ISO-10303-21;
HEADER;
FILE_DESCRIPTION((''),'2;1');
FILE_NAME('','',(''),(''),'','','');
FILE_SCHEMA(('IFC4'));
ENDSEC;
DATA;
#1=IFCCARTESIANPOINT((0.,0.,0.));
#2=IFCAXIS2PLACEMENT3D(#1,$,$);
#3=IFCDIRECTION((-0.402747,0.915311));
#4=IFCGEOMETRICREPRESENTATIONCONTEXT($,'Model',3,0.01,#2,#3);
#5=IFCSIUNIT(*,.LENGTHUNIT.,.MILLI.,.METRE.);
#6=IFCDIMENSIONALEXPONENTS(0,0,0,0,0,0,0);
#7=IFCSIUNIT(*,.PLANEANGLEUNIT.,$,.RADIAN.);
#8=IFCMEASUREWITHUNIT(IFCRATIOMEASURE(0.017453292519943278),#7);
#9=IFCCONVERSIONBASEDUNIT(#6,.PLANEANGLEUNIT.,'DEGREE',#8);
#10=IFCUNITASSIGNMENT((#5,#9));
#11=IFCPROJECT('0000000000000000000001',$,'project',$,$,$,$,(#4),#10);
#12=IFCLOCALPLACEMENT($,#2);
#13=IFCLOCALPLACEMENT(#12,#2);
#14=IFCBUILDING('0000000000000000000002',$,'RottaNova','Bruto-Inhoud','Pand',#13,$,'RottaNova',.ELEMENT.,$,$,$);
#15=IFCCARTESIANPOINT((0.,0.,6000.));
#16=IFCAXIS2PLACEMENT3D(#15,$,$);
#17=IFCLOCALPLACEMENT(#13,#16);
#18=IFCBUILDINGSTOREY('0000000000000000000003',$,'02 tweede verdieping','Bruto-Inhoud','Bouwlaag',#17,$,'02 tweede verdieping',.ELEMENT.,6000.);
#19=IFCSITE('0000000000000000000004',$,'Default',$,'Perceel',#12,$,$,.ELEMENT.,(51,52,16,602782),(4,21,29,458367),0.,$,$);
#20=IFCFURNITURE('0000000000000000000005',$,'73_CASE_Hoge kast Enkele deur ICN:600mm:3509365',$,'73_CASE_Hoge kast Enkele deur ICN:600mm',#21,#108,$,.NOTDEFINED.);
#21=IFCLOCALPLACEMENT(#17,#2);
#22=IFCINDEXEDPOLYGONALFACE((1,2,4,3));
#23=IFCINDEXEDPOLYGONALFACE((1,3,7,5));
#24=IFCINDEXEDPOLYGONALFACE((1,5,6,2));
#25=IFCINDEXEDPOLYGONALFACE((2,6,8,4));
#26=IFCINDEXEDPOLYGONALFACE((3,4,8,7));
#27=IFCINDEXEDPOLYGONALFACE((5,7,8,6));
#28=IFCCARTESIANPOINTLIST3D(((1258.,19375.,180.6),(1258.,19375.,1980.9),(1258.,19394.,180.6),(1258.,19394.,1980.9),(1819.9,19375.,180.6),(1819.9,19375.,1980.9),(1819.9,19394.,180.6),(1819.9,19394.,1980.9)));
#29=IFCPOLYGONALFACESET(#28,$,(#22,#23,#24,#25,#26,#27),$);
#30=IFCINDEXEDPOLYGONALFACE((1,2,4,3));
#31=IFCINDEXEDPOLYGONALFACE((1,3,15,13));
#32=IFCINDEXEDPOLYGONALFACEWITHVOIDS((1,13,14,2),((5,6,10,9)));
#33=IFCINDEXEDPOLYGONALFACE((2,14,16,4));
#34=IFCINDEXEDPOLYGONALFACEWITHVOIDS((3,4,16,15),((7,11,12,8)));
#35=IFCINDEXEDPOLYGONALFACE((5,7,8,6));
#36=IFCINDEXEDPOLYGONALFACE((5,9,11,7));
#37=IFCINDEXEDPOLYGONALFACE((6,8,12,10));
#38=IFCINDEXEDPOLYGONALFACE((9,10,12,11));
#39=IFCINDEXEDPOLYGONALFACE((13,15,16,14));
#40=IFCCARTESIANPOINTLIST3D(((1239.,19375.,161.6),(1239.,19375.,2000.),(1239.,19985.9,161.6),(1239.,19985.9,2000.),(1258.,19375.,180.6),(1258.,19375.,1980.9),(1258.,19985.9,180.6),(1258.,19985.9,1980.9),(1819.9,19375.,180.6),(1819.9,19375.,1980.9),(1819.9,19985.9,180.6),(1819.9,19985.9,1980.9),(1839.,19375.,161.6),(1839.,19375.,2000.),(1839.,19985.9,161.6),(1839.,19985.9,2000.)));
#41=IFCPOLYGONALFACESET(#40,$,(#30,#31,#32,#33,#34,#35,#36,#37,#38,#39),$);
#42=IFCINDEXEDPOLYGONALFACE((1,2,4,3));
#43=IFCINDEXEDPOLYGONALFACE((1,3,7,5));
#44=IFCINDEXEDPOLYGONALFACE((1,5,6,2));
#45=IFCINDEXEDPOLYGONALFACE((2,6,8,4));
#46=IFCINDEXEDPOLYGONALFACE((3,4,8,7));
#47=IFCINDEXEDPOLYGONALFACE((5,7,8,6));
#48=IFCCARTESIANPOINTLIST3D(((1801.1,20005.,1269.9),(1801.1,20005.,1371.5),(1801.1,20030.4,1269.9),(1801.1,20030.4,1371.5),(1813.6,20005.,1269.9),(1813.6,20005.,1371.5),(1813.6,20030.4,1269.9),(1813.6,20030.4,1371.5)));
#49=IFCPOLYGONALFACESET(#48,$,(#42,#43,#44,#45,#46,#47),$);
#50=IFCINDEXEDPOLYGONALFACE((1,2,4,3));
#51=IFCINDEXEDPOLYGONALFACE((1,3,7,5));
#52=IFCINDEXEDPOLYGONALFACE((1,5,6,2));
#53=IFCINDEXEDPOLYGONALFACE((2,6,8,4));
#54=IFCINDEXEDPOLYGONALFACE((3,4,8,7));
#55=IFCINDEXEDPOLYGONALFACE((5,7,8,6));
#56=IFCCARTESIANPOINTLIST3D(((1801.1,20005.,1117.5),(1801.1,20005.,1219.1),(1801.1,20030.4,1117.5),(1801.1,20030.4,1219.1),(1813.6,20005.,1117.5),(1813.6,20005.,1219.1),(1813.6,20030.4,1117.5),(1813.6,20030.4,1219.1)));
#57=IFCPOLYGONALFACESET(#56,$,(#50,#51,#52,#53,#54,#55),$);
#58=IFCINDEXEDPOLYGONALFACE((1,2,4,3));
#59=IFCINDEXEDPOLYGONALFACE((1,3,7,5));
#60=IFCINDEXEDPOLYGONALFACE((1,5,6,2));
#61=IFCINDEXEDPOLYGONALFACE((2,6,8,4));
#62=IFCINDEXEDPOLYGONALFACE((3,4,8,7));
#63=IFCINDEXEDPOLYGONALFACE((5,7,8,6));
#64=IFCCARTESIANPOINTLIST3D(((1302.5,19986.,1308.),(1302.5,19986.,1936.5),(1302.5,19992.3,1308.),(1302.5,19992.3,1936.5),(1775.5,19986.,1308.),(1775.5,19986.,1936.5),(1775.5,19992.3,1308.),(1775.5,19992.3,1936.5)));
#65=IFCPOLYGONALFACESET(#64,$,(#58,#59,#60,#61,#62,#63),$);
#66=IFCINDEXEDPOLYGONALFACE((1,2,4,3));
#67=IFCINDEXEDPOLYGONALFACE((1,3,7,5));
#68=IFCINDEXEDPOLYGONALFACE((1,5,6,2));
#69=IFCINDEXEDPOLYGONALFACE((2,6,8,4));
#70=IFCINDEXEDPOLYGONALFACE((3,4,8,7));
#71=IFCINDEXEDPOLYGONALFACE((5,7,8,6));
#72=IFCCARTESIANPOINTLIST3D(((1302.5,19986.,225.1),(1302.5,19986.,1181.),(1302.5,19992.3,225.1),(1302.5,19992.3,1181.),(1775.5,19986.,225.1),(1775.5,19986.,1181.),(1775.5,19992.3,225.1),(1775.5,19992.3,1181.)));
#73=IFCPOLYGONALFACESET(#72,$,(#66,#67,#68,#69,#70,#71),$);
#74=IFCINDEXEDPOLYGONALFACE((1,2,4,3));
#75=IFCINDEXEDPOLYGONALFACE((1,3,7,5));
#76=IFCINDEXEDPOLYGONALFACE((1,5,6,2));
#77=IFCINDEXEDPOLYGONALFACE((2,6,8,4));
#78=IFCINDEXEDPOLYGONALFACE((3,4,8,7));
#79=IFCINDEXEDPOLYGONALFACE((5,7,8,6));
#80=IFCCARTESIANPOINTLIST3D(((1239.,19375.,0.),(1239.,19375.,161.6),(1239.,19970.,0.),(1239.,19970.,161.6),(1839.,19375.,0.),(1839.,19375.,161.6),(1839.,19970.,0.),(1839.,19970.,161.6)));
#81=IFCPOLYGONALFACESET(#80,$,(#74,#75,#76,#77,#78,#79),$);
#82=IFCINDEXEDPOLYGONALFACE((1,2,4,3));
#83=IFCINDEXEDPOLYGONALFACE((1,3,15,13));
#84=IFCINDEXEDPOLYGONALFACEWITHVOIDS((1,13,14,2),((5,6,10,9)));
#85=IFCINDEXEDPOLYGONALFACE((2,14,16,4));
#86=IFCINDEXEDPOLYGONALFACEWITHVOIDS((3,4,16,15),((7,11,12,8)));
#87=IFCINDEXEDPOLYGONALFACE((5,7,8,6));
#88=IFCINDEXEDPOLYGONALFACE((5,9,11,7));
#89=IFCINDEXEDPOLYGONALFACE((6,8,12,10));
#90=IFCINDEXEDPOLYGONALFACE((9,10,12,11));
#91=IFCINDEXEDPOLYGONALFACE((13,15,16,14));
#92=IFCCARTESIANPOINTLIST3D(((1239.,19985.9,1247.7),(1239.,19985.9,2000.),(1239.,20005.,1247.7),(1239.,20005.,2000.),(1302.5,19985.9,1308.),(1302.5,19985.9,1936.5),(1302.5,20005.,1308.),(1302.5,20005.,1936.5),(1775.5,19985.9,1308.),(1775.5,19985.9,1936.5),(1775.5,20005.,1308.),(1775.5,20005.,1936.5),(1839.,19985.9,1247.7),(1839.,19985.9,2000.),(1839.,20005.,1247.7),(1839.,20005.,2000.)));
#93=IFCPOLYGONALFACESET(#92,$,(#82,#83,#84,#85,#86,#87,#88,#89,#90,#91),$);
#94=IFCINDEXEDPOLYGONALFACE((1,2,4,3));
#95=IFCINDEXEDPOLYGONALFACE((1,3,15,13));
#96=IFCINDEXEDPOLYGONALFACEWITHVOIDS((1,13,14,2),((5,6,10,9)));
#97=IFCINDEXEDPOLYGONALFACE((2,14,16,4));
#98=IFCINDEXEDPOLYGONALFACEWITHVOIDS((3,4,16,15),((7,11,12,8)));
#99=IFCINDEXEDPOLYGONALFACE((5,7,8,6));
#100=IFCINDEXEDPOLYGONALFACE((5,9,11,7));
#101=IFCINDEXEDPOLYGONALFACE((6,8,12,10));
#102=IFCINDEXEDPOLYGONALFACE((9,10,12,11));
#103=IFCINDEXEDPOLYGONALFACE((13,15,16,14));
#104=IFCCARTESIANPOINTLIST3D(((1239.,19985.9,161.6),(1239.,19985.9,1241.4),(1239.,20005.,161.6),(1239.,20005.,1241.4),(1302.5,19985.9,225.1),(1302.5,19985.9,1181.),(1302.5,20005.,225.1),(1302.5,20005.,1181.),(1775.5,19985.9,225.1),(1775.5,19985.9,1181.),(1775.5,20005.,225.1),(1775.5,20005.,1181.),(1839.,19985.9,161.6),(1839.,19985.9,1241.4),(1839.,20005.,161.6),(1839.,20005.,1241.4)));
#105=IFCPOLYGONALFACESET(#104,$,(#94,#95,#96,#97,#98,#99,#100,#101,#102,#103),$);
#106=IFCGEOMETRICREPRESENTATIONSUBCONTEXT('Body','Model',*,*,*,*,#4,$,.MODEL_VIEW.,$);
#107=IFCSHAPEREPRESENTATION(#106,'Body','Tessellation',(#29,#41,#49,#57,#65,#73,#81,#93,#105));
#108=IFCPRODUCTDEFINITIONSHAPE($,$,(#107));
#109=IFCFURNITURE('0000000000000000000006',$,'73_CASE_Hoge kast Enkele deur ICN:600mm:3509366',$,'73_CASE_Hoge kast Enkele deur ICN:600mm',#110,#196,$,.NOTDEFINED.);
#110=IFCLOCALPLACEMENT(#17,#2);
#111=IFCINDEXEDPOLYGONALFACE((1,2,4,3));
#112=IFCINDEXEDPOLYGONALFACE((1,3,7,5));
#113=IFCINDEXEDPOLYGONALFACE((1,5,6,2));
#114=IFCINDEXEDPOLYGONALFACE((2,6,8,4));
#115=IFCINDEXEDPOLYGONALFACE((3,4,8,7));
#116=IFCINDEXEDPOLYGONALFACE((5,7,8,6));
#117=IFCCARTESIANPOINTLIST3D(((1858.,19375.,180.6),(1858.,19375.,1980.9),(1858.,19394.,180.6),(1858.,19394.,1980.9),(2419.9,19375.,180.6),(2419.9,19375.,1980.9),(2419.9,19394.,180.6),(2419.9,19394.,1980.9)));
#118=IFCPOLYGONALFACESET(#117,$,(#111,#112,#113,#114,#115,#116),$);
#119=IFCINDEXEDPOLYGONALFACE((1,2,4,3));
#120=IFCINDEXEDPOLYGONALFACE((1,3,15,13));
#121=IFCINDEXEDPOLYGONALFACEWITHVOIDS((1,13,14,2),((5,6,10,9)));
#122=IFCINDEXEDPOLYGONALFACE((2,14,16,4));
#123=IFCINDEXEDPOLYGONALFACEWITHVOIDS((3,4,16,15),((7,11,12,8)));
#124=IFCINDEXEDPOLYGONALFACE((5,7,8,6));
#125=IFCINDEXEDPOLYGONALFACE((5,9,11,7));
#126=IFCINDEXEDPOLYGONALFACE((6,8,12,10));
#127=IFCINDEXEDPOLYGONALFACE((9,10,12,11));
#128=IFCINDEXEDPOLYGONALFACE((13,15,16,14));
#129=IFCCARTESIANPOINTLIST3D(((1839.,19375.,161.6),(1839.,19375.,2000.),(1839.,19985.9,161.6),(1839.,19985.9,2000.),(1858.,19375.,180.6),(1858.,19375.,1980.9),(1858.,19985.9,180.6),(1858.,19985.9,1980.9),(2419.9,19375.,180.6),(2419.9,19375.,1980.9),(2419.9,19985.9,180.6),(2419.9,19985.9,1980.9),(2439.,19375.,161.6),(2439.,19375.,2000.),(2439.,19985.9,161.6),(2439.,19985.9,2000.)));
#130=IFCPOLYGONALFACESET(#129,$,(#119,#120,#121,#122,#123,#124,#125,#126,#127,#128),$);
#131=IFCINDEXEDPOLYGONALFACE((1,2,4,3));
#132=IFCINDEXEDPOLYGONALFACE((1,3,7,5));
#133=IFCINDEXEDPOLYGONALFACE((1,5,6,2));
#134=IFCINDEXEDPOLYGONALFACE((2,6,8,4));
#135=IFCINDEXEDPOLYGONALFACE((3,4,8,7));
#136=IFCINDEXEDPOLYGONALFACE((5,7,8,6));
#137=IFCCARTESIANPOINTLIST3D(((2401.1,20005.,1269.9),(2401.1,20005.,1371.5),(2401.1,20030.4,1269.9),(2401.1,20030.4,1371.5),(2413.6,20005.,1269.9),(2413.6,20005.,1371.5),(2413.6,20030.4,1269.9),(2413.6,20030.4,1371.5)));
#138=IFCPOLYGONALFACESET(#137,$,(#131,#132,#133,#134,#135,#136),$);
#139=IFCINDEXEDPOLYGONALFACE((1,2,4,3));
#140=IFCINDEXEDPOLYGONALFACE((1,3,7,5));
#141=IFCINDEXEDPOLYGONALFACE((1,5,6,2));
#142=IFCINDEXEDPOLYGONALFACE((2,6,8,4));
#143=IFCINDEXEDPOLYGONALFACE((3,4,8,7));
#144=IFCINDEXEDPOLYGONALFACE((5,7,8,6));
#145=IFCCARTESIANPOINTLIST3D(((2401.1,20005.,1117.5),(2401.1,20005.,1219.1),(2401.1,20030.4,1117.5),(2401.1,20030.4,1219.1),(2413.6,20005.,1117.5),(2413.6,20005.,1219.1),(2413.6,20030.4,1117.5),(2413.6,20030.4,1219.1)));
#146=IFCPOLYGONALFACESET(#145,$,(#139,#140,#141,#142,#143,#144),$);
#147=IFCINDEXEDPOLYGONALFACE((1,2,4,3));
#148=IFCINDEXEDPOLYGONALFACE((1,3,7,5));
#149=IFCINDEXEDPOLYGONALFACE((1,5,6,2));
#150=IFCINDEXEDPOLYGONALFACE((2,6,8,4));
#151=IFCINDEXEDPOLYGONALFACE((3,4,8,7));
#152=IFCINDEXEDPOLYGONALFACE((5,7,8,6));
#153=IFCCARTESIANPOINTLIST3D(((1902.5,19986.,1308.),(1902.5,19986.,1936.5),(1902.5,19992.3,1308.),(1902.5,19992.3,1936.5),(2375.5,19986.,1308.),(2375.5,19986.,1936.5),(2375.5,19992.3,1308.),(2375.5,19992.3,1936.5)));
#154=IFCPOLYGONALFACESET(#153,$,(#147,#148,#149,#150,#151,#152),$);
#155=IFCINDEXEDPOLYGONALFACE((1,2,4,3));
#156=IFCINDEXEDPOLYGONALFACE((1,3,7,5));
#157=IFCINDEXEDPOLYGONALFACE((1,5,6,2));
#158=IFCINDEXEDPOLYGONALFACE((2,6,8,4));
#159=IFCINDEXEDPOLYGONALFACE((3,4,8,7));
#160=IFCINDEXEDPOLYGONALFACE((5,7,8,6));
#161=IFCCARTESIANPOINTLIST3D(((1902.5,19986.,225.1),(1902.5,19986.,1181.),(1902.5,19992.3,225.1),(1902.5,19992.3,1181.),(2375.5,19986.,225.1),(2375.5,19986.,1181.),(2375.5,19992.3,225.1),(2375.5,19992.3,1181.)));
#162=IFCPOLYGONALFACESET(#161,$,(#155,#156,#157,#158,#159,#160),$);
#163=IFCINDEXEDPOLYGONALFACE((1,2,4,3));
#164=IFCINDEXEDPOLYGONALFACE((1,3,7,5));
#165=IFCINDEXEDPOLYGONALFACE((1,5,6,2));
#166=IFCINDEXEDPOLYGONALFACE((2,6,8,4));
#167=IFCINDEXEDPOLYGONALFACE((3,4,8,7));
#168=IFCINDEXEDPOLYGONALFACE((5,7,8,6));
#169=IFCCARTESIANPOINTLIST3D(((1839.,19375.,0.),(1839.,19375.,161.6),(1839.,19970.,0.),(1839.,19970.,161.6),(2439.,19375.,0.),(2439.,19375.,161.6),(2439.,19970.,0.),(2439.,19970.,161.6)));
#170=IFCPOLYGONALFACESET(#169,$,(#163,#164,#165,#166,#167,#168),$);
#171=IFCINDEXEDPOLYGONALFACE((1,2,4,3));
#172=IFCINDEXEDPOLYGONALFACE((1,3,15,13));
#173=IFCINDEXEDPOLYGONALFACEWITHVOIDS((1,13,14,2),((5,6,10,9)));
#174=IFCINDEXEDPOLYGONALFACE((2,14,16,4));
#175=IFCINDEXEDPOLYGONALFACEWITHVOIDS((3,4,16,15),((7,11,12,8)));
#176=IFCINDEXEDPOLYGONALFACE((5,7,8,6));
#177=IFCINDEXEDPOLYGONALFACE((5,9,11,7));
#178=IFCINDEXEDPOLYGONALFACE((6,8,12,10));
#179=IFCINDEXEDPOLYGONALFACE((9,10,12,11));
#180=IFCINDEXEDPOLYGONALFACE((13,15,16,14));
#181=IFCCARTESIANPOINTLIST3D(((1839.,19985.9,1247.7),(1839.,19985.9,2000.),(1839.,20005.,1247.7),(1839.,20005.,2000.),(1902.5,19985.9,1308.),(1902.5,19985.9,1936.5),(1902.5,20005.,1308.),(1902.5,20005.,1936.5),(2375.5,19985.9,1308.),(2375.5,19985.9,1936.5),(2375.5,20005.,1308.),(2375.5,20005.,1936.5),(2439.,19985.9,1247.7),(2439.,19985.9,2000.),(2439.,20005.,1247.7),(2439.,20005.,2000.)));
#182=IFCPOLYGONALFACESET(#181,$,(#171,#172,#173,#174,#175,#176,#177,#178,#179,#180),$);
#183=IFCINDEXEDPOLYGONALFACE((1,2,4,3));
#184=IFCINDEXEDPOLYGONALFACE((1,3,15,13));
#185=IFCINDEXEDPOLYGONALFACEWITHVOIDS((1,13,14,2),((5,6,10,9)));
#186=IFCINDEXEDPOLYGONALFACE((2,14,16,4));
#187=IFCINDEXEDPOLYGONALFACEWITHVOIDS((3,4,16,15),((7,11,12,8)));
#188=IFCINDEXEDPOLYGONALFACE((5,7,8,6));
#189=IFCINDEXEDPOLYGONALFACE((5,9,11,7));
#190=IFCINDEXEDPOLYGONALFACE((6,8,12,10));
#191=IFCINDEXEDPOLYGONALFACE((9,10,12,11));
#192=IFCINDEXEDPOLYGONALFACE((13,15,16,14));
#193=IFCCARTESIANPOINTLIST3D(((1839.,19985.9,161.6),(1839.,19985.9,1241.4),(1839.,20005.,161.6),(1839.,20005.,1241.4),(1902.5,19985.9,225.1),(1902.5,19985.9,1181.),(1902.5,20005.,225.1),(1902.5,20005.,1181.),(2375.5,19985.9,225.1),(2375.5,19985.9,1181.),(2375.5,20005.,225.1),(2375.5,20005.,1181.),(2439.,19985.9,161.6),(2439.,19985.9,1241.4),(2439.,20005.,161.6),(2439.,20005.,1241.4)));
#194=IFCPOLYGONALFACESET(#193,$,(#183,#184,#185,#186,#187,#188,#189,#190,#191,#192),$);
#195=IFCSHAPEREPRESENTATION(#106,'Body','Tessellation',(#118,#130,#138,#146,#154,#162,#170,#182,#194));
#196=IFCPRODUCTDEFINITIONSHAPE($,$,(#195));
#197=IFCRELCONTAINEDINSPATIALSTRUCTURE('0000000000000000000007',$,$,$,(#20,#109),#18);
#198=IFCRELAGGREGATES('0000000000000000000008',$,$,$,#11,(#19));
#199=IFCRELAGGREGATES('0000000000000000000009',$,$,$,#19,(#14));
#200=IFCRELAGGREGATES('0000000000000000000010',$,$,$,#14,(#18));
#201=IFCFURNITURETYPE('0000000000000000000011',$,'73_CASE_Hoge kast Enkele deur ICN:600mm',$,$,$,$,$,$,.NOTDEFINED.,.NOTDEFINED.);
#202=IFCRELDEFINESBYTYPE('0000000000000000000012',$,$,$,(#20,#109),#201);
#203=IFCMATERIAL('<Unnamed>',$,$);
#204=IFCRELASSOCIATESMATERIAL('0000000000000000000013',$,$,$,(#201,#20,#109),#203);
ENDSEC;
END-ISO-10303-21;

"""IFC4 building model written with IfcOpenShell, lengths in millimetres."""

from ifc_helpers import new_model, entity, si_unit, converted_unit, direction, frame, frame_2d, origin, origin_2d_with_axis, place, context, subcontext, project, spatial, polyline, rectangle, outline, extrude, source, transform, mapped, material, type_object, type_shapes, element, save


model = new_model("IFC4")

# Units and contexts
model_context = context("Model", 3, precision=0.01, world=origin(), true_north=direction((-0.402747, 0.915311)))
body_context = subcontext(model_context, "Body", "Model", "MODEL_VIEW")
ifc_project = project(units=[si_unit("LENGTHUNIT", "METRE", prefix="MILLI"), converted_unit("PLANEANGLEUNIT", "DEGREE", entity("IfcRatioMeasure", 0.017453292519943278), si_unit("PLANEANGLEUNIT", "RADIAN"), dimensions=[0, 0, 0, 0, 0, 0, 0])], contexts=[model_context])

# Site, building, storey
site_placement = place(None, origin())
site = spatial("IfcSite", under=ifc_project, at=site_placement, Name="Default", ObjectType="Perceel", CompositionType="ELEMENT", RefLatitude=(51, 52, 16, 602782), RefLongitude=(4, 21, 29, 458367), RefElevation=0.0)
building_placement = place(site_placement, origin())
building = spatial("IfcBuilding", under=site, at=building_placement, Name="RottaNova", Description="Bruto-Inhoud", ObjectType="Pand", LongName="RottaNova", CompositionType="ELEMENT")
storey_placement = place(building_placement, frame((0.0, 0.0, 6000.0)))
storey = spatial("IfcBuildingStorey", under=building, at=storey_placement, Name="02 tweede verdieping", Description="Bruto-Inhoud", ObjectType="Bouwlaag", LongName="02 tweede verdieping", CompositionType="ELEMENT", Elevation=6000.0)

# Furniture
ifc_material_1 = material(Name="<Unnamed>")
furniture_type = type_object("IfcFurnitureType", Name="73_CASE_Hoge kast Enkele deur ICN:600mm", AssemblyPlace="NOTDEFINED", PredefinedType="NOTDEFINED", material=ifc_material_1)
shared_shape_1 = source(origin(), body_context, "Body", "SweptSolid", [
    extrude(rectangle(XDim=561.9, YDim=19.1, at=origin_2d_with_axis()), frame((18.7, 9.5, 180.6), z_axis=(0.0, 0.0, 1.0), x_axis=(-1.0, 0.0, 0.0)), (0.0, 0.0, 1.0), 1800.3),
    extrude(outline(polyline([(-300.0, -919.2), (300.0, -919.2), (300.0, 919.2), (-300.0, 919.2), (-300.0, -919.2)]), holes=[polyline([(-280.9, 900.2), (281.0, 900.2), (281.0, -900.2), (-280.9, -900.2), (-280.9, 900.2)])]), frame((18.7, 0.0, 1080.8), z_axis=(0.0, 1.0, 0.0), x_axis=(-1.0, 0.0, 0.0)), (0.0, 0.0, 1.0), 610.9),
    extrude(rectangle(XDim=12.5, YDim=25.4, at=frame_2d((0.0, 0.0), x_axis=(1.0, 0.0))), frame((287.1, 642.7, 1269.9), z_axis=(0.0, 0.0, 1.0), x_axis=(-1.0, 0.0, 0.0)), (0.0, 0.0, 1.0), 101.6),
    extrude(rectangle(XDim=12.5, YDim=25.4, at=frame_2d((0.0, 0.0), x_axis=(1.0, 0.0))), frame((287.1, 642.7, 1117.5), z_axis=(0.0, 0.0, 1.0), x_axis=(-1.0, 0.0, 0.0)), (0.0, 0.0, 1.0), 101.6),
    extrude(rectangle(XDim=473.0, YDim=6.4, at=origin_2d_with_axis()), frame((18.7, 614.1, 1308.0), z_axis=(0.0, 0.0, 1.0), x_axis=(-1.0, 0.0, 0.0)), (0.0, 0.0, 1.0), 628.5),
    extrude(rectangle(XDim=473.0, YDim=6.4, at=origin_2d_with_axis()), frame((18.7, 614.1, 225.1), z_axis=(0.0, 0.0, 1.0), x_axis=(-1.0, 0.0, 0.0)), (0.0, 0.0, 1.0), 956.0),
    extrude(rectangle(XDim=595.0, YDim=600.0, at=frame_2d((0.0, 0.0), x_axis=(1.0, 0.0))), frame((18.7, 297.5, 0.0), z_axis=(0.0, 0.0, 1.0), x_axis=(0.0, 1.0, 0.0)), (0.0, 0.0, 1.0), 161.6),
    extrude(outline(polyline([(-376.1, -300.0), (376.1, -300.0), (376.1, 300.0), (-376.1, 300.0), (-376.1, -300.0)]), holes=[polyline([(-312.6, -236.5), (-312.6, 236.5), (315.8, 236.5), (315.8, -236.5), (-312.6, -236.5)])]), frame((18.7, 610.9, 1623.9), z_axis=(0.0, 1.0, 0.0), x_axis=(0.0, 0.0, -1.0)), (0.0, 0.0, 1.0), 19.1),
    extrude(outline(polyline([(-300.0, -539.9), (300.0, -539.9), (300.0, 539.9), (-300.0, 539.9), (-300.0, -539.9)]), holes=[polyline([(-236.5, 479.6), (236.5, 479.6), (236.5, -476.4), (-236.5, -476.4), (-236.5, 479.6)])]), frame((18.7, 610.9, 701.5), z_axis=(0.0, 1.0, 0.0), x_axis=(-1.0, 0.0, 0.0)), (0.0, 0.0, 1.0), 19.1),
])
type_shapes(furniture_type, [shared_shape_1])
for number, where, name in (
    (1, (1520.3, 19375.0, 0.0), "73_CASE_Hoge kast Enkele deur ICN:600mm:3509365"),
    (2, (2120.3, 19375.0, 0.0), "73_CASE_Hoge kast Enkele deur ICN:600mm:3509366"),
):
    element("IfcFurniture", number, at=place(storey_placement, frame(where)), inside=storey, type_object=furniture_type, material=ifc_material_1, Name=name, ObjectType="73_CASE_Hoge kast Enkele deur ICN:600mm", PredefinedType="NOTDEFINED", context=body_context, shape_type="MappedRepresentation", body=[
        mapped(shared_shape_1, transform((0.0, 0.0, 0.0), scale=1.0)),
    ])

save(model, "model.ifc")
